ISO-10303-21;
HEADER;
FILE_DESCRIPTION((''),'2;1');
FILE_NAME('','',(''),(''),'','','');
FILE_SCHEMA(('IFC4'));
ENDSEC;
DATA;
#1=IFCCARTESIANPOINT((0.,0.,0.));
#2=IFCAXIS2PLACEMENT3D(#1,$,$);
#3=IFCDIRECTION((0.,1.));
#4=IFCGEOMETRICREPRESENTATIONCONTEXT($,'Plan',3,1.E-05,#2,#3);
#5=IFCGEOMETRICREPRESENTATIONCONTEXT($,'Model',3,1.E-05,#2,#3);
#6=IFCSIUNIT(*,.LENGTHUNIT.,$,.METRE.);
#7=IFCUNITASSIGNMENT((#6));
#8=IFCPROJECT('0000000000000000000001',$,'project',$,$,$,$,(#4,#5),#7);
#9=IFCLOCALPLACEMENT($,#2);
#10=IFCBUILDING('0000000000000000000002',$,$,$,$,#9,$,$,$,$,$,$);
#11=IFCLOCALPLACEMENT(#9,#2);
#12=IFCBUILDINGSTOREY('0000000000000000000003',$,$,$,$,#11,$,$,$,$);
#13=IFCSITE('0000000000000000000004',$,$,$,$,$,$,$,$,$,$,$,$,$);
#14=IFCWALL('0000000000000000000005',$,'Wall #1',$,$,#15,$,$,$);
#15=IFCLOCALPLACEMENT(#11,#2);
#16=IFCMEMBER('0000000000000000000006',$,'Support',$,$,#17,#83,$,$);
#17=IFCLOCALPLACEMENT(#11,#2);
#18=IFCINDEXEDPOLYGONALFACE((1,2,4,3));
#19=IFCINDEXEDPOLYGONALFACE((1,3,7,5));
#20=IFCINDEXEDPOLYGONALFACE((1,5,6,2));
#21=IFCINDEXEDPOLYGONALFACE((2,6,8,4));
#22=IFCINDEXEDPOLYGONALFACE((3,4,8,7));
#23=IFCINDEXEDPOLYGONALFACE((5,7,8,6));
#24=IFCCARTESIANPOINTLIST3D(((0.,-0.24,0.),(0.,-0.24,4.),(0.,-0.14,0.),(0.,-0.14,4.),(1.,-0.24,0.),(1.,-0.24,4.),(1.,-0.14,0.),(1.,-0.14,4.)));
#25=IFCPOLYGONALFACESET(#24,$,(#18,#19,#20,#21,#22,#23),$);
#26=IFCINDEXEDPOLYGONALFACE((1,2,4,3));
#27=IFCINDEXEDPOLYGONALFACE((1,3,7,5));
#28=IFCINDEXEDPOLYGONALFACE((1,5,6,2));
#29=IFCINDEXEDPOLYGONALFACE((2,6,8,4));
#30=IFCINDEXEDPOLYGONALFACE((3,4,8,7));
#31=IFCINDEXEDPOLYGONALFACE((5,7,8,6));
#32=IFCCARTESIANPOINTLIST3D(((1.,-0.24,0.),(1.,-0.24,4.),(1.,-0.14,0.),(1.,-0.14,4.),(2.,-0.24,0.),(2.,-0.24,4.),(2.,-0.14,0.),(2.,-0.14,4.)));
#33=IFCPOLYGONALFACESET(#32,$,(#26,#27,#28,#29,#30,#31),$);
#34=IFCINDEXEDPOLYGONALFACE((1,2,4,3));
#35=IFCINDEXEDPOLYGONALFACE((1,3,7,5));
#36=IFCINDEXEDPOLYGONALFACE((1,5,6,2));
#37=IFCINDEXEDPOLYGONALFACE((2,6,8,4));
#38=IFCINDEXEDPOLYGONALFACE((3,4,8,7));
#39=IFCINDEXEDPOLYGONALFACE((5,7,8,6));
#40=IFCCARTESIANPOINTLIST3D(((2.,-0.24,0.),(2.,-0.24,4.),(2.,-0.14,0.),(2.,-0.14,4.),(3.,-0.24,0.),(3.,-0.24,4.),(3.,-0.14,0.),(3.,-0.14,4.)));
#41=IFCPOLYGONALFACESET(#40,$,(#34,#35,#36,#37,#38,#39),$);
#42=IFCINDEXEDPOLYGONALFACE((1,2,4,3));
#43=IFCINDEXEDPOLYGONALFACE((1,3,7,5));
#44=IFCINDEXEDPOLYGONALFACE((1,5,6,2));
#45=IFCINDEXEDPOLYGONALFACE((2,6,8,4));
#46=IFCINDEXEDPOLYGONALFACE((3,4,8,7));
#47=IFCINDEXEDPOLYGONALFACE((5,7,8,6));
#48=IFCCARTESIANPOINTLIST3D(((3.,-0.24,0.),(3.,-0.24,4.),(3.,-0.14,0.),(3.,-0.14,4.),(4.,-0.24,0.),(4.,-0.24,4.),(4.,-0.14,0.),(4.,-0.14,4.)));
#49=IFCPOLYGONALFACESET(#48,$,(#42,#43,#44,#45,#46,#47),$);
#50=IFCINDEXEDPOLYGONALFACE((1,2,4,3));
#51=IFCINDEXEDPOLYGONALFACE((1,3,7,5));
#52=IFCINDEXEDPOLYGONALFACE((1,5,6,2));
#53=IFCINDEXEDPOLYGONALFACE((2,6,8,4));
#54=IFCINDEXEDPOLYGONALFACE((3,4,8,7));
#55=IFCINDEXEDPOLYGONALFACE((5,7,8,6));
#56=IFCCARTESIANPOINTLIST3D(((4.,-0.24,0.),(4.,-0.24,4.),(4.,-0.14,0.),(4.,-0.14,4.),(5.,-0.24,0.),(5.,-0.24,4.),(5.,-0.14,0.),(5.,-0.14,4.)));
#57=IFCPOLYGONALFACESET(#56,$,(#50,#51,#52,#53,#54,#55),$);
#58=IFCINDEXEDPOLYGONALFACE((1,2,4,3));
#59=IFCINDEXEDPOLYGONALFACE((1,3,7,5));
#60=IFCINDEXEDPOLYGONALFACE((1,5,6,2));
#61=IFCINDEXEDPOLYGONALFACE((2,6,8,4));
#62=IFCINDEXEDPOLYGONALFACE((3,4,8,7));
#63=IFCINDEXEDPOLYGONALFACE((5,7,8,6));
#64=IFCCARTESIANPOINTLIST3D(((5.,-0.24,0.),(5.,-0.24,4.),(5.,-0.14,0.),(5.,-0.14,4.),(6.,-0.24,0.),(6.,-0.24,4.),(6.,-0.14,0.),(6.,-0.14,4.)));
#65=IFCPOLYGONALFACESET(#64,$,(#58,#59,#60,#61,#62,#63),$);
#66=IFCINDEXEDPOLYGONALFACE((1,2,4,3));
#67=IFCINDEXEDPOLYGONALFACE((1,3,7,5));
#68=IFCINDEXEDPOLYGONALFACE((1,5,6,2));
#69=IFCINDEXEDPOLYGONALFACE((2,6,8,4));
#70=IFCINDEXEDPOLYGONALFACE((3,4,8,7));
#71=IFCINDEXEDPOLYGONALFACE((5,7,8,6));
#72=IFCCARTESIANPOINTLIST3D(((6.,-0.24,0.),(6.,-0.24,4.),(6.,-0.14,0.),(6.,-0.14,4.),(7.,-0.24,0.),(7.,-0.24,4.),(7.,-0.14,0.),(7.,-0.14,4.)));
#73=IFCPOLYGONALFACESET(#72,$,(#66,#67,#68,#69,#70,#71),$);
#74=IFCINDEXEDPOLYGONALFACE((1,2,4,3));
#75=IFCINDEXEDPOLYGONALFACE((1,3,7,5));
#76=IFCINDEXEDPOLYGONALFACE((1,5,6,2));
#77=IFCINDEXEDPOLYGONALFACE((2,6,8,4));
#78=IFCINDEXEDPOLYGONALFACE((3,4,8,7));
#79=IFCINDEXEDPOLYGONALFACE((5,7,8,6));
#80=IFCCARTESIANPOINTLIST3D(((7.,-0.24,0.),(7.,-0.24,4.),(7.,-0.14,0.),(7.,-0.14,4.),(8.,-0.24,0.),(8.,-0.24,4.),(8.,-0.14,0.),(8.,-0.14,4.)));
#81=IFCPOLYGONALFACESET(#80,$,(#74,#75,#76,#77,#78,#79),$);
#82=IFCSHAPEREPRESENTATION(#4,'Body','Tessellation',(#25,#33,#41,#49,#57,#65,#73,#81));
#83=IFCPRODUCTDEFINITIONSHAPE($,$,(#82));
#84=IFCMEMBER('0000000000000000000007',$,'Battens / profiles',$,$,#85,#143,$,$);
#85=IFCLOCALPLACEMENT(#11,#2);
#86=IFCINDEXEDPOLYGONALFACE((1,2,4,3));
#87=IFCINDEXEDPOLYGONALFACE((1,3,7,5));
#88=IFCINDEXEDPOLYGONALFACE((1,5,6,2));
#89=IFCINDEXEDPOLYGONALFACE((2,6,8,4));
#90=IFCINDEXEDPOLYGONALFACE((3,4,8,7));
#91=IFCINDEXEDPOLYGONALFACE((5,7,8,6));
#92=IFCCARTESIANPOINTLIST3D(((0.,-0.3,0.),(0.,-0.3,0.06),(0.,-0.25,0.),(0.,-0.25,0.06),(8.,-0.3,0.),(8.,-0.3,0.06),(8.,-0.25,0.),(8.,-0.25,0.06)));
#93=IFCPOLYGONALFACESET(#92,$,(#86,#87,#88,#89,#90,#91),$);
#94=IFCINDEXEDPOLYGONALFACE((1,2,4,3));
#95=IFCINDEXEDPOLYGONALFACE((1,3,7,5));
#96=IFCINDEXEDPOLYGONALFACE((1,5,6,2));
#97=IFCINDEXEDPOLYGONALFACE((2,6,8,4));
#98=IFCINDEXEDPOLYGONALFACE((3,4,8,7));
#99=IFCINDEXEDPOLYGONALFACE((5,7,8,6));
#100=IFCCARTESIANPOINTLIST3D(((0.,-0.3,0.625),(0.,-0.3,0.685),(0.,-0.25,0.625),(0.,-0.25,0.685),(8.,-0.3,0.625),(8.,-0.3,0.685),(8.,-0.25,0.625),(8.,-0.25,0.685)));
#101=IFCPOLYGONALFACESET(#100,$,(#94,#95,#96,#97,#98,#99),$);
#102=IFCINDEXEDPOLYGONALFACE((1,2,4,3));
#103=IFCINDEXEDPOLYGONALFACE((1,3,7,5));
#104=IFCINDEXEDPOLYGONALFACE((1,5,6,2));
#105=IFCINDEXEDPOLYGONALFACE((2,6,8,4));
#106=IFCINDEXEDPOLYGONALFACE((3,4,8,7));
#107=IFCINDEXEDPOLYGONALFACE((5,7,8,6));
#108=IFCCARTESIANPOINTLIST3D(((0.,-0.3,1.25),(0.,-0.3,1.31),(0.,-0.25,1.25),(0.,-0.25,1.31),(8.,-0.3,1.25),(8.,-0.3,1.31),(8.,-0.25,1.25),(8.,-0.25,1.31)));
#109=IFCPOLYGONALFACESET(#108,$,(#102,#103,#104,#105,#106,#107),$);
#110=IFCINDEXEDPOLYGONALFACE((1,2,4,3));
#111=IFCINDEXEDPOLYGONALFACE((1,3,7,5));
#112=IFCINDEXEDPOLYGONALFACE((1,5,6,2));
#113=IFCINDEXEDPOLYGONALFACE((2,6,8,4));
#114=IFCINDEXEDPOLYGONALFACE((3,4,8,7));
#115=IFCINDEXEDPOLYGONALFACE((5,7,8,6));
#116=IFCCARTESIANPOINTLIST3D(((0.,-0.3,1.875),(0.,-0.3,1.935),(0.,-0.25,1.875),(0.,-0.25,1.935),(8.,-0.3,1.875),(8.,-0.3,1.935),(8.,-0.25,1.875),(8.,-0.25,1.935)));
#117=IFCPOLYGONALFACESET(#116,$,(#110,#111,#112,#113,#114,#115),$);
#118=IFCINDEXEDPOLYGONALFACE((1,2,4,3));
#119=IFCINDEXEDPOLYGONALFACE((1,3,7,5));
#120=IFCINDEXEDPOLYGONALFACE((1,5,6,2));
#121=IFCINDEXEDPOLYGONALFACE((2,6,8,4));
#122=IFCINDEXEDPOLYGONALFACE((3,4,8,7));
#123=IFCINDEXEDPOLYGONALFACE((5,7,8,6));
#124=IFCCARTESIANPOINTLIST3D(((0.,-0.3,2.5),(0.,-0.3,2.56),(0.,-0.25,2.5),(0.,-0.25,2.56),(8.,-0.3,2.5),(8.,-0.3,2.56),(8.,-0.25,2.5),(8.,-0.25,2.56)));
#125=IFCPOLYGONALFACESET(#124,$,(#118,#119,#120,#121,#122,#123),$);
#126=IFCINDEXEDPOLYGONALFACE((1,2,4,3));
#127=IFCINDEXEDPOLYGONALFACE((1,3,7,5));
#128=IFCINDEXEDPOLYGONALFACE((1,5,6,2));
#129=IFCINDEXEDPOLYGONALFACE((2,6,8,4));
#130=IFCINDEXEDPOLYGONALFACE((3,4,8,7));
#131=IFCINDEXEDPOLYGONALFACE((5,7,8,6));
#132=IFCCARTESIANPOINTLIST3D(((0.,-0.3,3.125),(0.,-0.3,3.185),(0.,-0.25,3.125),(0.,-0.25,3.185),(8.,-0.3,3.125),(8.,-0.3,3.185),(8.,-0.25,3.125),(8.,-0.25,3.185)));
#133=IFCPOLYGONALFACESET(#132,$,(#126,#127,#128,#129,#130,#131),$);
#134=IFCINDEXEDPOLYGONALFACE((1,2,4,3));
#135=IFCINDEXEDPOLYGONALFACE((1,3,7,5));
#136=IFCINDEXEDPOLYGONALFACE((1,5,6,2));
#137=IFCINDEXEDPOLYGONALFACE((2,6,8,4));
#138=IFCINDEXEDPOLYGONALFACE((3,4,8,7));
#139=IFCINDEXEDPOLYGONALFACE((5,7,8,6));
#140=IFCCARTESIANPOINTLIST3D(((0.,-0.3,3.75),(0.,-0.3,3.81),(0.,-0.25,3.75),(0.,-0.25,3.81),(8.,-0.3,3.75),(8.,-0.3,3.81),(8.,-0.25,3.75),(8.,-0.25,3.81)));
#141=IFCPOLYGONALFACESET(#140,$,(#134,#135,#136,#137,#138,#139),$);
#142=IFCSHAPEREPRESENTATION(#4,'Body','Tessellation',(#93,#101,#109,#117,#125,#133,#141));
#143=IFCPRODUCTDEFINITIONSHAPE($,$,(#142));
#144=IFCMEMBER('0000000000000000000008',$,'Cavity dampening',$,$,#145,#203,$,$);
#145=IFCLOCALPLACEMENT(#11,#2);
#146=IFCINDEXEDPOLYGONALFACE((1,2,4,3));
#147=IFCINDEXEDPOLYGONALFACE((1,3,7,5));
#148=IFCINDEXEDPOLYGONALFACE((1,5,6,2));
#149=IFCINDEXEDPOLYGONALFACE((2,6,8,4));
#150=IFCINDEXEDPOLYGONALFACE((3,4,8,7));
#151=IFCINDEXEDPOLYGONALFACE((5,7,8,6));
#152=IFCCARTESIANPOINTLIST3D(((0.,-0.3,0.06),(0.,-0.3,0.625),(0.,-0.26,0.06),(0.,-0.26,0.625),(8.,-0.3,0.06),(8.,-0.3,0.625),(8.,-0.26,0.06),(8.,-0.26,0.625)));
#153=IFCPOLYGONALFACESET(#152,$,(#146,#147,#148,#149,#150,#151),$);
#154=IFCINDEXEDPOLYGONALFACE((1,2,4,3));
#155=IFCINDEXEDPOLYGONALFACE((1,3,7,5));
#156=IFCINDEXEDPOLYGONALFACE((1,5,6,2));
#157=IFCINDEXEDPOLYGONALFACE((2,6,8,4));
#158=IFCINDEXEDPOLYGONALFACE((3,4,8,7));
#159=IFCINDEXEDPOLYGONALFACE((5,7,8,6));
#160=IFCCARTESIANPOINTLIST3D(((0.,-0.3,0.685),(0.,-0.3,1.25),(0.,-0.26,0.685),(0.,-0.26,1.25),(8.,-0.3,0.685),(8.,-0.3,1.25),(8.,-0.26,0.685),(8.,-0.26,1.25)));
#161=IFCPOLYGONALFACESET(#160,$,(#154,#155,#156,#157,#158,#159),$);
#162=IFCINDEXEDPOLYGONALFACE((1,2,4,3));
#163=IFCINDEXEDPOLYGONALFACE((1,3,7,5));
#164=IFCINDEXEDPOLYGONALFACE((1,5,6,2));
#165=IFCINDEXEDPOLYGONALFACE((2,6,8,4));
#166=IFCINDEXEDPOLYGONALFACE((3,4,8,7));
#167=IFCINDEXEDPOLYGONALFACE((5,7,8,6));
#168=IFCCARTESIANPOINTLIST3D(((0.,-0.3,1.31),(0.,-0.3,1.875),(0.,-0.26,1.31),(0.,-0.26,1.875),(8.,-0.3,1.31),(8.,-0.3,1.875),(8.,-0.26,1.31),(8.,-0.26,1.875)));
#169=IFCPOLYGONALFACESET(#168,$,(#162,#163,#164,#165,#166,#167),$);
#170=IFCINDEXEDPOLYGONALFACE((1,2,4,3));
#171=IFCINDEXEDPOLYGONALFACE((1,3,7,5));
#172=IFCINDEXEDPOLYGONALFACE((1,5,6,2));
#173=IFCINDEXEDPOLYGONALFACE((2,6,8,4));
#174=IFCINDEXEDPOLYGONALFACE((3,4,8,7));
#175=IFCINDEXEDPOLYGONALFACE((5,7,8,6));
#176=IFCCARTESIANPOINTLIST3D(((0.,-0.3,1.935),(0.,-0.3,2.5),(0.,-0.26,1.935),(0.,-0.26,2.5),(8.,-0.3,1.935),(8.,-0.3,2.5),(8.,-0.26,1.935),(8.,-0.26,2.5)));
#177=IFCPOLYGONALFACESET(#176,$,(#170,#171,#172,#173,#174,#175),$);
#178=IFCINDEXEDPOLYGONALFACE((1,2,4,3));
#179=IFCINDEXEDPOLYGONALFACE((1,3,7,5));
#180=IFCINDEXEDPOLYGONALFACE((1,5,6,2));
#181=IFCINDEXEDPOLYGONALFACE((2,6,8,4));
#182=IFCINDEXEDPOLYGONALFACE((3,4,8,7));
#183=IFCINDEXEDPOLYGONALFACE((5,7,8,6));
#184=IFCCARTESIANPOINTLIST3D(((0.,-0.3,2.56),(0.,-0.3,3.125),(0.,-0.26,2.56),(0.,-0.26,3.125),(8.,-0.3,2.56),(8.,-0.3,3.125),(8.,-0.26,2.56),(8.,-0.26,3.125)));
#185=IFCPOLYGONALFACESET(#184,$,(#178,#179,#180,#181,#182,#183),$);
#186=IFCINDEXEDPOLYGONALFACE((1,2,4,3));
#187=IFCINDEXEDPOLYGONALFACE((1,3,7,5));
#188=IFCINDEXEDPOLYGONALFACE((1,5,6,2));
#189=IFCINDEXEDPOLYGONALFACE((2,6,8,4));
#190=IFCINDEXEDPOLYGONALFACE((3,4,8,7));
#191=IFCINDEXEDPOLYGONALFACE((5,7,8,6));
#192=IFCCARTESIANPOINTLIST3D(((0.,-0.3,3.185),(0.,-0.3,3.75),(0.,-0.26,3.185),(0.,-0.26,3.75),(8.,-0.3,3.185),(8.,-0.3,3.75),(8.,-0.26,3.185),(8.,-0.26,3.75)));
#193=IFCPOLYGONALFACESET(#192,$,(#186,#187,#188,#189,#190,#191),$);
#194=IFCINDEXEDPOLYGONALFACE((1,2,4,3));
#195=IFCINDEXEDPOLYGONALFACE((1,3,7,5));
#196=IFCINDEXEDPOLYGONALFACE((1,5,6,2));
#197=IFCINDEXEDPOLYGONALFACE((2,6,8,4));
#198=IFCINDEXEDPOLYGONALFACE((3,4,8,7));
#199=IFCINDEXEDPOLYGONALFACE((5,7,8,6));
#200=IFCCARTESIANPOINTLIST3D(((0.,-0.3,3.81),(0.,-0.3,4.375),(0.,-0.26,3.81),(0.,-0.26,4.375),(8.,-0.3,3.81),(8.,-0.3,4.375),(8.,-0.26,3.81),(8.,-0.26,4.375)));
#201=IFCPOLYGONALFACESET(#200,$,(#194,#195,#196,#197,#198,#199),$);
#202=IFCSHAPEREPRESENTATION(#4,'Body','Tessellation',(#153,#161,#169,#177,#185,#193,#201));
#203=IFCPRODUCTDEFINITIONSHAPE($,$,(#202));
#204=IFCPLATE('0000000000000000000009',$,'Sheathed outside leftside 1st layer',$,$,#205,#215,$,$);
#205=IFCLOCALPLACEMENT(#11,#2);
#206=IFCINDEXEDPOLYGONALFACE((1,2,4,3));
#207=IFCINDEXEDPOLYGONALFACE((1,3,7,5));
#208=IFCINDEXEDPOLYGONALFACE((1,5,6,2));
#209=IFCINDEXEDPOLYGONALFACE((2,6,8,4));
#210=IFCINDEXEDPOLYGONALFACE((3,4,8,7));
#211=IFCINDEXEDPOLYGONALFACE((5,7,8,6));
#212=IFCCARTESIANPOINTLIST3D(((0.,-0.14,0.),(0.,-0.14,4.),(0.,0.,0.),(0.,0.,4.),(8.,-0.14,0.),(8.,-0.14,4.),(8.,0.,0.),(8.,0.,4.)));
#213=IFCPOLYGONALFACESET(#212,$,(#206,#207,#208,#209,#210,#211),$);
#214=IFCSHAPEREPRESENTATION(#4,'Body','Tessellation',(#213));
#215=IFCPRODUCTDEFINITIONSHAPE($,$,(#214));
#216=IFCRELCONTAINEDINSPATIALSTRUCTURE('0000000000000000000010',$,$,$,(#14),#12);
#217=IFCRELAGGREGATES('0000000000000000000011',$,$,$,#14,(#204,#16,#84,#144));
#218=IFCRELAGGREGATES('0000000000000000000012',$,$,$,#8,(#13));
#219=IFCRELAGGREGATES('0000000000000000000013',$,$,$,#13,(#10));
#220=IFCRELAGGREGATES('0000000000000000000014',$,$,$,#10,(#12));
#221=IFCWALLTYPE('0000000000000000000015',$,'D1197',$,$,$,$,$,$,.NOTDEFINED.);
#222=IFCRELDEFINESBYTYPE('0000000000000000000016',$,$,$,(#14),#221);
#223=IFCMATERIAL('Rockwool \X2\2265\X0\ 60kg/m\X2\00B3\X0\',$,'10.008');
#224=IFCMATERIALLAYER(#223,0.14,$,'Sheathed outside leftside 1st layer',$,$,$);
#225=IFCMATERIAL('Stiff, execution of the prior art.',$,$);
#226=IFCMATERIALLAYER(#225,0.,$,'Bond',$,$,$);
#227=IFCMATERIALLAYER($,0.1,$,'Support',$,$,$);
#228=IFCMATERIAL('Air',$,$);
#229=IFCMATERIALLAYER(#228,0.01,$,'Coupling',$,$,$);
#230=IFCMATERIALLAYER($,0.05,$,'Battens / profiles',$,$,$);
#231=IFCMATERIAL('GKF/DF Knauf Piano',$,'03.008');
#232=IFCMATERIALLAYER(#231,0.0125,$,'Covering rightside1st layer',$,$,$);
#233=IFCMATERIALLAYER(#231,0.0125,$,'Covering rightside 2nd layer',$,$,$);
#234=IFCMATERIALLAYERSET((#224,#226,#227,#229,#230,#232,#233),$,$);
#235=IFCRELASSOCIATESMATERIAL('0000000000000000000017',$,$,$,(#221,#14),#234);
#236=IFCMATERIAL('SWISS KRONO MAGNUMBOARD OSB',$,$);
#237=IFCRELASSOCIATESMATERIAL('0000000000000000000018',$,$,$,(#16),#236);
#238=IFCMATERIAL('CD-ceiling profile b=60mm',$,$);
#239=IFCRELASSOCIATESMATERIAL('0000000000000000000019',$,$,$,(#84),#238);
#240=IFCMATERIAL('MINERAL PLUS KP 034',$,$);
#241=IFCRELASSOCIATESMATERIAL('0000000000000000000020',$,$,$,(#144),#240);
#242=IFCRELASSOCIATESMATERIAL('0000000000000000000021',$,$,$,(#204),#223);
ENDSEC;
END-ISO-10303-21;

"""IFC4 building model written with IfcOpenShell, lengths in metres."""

from ifc_helpers import new_model, si_unit, direction, frame, frame_2d, origin, origin_with_axes, place, context, project, spatial, rectangle, extrude, material, layer, layer_set, type_object, element, aggregate, save


model = new_model("IFC4")

# Units and contexts
plan_context = context("Plan", 3, precision=1e-05, world=origin(), true_north=direction((0.0, 1.0)))
model_context = context("Model", 3, precision=1e-05, world=origin(), true_north=direction((0.0, 1.0)))
ifc_project = project(units=[si_unit("LENGTHUNIT", "METRE")], contexts=[plan_context, model_context])

# Site, building, storey
site = spatial("IfcSite", under=ifc_project)
building_placement = place(None, origin())
building = spatial("IfcBuilding", under=site, at=building_placement)
storey_placement = place(building_placement, origin())
storey = spatial("IfcBuildingStorey", under=building, at=storey_placement)

# Wall, members, plate
ifc_material_1 = material(Name="Rockwool ≥ 60kg/m³", Category="10.008")
ifc_layer_1 = layer(ifc_material_1, 0.14, Name="Sheathed outside leftside 1st layer")
ifc_material_2 = material(Name="Stiff, execution of the prior art.")
ifc_layer_2 = layer(ifc_material_2, 0.0, Name="Bond")
ifc_layer_3 = layer(None, 0.1, Name="Support")
ifc_material_3 = material(Name="Air")
ifc_layer_4 = layer(ifc_material_3, 0.01, Name="Coupling")
ifc_layer_5 = layer(None, 0.05, Name="Battens / profiles")
ifc_material_4 = material(Name="GKF/DF Knauf Piano", Category="03.008")
ifc_layer_6 = layer(ifc_material_4, 0.0125, Name="Covering rightside1st layer")
ifc_layer_7 = layer(ifc_material_4, 0.0125, Name="Covering rightside 2nd layer")
ifc_layer_set = layer_set([ifc_layer_1, ifc_layer_2, ifc_layer_3, ifc_layer_4, ifc_layer_5, ifc_layer_6, ifc_layer_7])
wall_type = type_object("IfcWallType", Name="D1197", PredefinedType="NOTDEFINED", material=ifc_layer_set)
wall_placement = place(None, frame((0.0, 0.0, 0.0), z_axis=(0.0, -1.0, 0.0), x_axis=(1.0, 0.0, 0.0)))
wall = element("IfcWall", 1, at=wall_placement, inside=storey, type_object=wall_type, material=ifc_layer_set, Name="Wall #1")
ifc_material_5 = material(Name="SWISS KRONO MAGNUMBOARD OSB")
member_1_placement = place(wall_placement, origin())
member_1 = element("IfcMember", 2, at=member_1_placement, material=ifc_material_5, Name="Support", context=plan_context, shape_type="SweptSolid", body=[
    extrude(rectangle(XDim=1.0, YDim=0.1, at=frame_2d((0.5, 0.05), x_axis=(1.0, 0.0))), frame((0.0, 4.0, 0.14), z_axis=(0.0, -1.0, 0.0), x_axis=(1.0, 0.0, 0.0)), (0.0, 0.0, 1.0), 4.0),
    extrude(rectangle(XDim=1.0, YDim=0.1, at=frame_2d((0.5, 0.05), x_axis=(1.0, 0.0))), frame((1.0, 4.0, 0.14), z_axis=(0.0, -1.0, 0.0), x_axis=(1.0, 0.0, 0.0)), (0.0, 0.0, 1.0), 4.0),
    extrude(rectangle(XDim=1.0, YDim=0.1, at=frame_2d((0.5, 0.05), x_axis=(1.0, 0.0))), frame((2.0, 4.0, 0.14), z_axis=(0.0, -1.0, 0.0), x_axis=(1.0, 0.0, 0.0)), (0.0, 0.0, 1.0), 4.0),
    extrude(rectangle(XDim=1.0, YDim=0.1, at=frame_2d((0.5, 0.05), x_axis=(1.0, 0.0))), frame((3.0, 4.0, 0.14), z_axis=(0.0, -1.0, 0.0), x_axis=(1.0, 0.0, 0.0)), (0.0, 0.0, 1.0), 4.0),
    extrude(rectangle(XDim=1.0, YDim=0.1, at=frame_2d((0.5, 0.05), x_axis=(1.0, 0.0))), frame((4.0, 4.0, 0.14), z_axis=(0.0, -1.0, 0.0), x_axis=(1.0, 0.0, 0.0)), (0.0, 0.0, 1.0), 4.0),
    extrude(rectangle(XDim=1.0, YDim=0.1, at=frame_2d((0.5, 0.05), x_axis=(1.0, 0.0))), frame((5.0, 4.0, 0.14), z_axis=(0.0, -1.0, 0.0), x_axis=(1.0, 0.0, 0.0)), (0.0, 0.0, 1.0), 4.0),
    extrude(rectangle(XDim=1.0, YDim=0.1, at=frame_2d((0.5, 0.05), x_axis=(1.0, 0.0))), frame((6.0, 4.0, 0.14), z_axis=(0.0, -1.0, 0.0), x_axis=(1.0, 0.0, 0.0)), (0.0, 0.0, 1.0), 4.0),
    extrude(rectangle(XDim=1.0, YDim=0.1, at=frame_2d((0.5, 0.05), x_axis=(1.0, 0.0))), frame((7.0, 4.0, 0.14), z_axis=(0.0, -1.0, 0.0), x_axis=(1.0, 0.0, 0.0)), (0.0, 0.0, 1.0), 4.0),
])
ifc_material_6 = material(Name="CD-ceiling profile b=60mm")
member_2_placement = place(wall_placement, origin())
member_2 = element("IfcMember", 3, at=member_2_placement, material=ifc_material_6, Name="Battens / profiles", context=plan_context, shape_type="SweptSolid", body=[
    extrude(rectangle(XDim=0.06, YDim=0.05, at=frame_2d((0.03, 0.025), x_axis=(1.0, 0.0))), frame((0.0, 0.0, 0.25), z_axis=(1.0, 0.0, 0.0), x_axis=(0.0, 1.0, 0.0)), (0.0, 0.0, 1.0), 8.0),
    extrude(rectangle(XDim=0.06, YDim=0.05, at=frame_2d((0.03, 0.025), x_axis=(1.0, 0.0))), frame((0.0, 0.625, 0.25), z_axis=(1.0, 0.0, 0.0), x_axis=(0.0, 1.0, 0.0)), (0.0, 0.0, 1.0), 8.0),
    extrude(rectangle(XDim=0.06, YDim=0.05, at=frame_2d((0.03, 0.025), x_axis=(1.0, 0.0))), frame((0.0, 1.25, 0.25), z_axis=(1.0, 0.0, 0.0), x_axis=(0.0, 1.0, 0.0)), (0.0, 0.0, 1.0), 8.0),
    extrude(rectangle(XDim=0.06, YDim=0.05, at=frame_2d((0.03, 0.025), x_axis=(1.0, 0.0))), frame((0.0, 1.875, 0.25), z_axis=(1.0, 0.0, 0.0), x_axis=(0.0, 1.0, 0.0)), (0.0, 0.0, 1.0), 8.0),
    extrude(rectangle(XDim=0.06, YDim=0.05, at=frame_2d((0.03, 0.025), x_axis=(1.0, 0.0))), frame((0.0, 2.5, 0.25), z_axis=(1.0, 0.0, 0.0), x_axis=(0.0, 1.0, 0.0)), (0.0, 0.0, 1.0), 8.0),
    extrude(rectangle(XDim=0.06, YDim=0.05, at=frame_2d((0.03, 0.025), x_axis=(1.0, 0.0))), frame((0.0, 3.125, 0.25), z_axis=(1.0, 0.0, 0.0), x_axis=(0.0, 1.0, 0.0)), (0.0, 0.0, 1.0), 8.0),
    extrude(rectangle(XDim=0.06, YDim=0.05, at=frame_2d((0.03, 0.025), x_axis=(1.0, 0.0))), frame((0.0, 3.75, 0.25), z_axis=(1.0, 0.0, 0.0), x_axis=(0.0, 1.0, 0.0)), (0.0, 0.0, 1.0), 8.0),
])
ifc_material_7 = material(Name="MINERAL PLUS KP 034")
member_3_placement = place(wall_placement, origin())
member_3 = element("IfcMember", 4, at=member_3_placement, material=ifc_material_7, Name="Cavity dampening", context=plan_context, shape_type="SweptSolid", body=[
    extrude(rectangle(XDim=0.565, YDim=0.04, at=frame_2d((0.2825, 0.02), x_axis=(1.0, 0.0))), frame((0.0, 0.06, 0.26), z_axis=(1.0, 0.0, 0.0), x_axis=(0.0, 1.0, 0.0)), (0.0, 0.0, 1.0), 8.0),
    extrude(rectangle(XDim=0.565, YDim=0.04, at=frame_2d((0.2825, 0.02), x_axis=(1.0, 0.0))), frame((0.0, 0.685, 0.26), z_axis=(1.0, 0.0, 0.0), x_axis=(0.0, 1.0, 0.0)), (0.0, 0.0, 1.0), 8.0),
    extrude(rectangle(XDim=0.565, YDim=0.04, at=frame_2d((0.2825, 0.02), x_axis=(1.0, 0.0))), frame((0.0, 1.31, 0.26), z_axis=(1.0, 0.0, 0.0), x_axis=(0.0, 1.0, 0.0)), (0.0, 0.0, 1.0), 8.0),
    extrude(rectangle(XDim=0.565, YDim=0.04, at=frame_2d((0.2825, 0.02), x_axis=(1.0, 0.0))), frame((0.0, 1.935, 0.26), z_axis=(1.0, 0.0, 0.0), x_axis=(0.0, 1.0, 0.0)), (0.0, 0.0, 1.0), 8.0),
    extrude(rectangle(XDim=0.565, YDim=0.04, at=frame_2d((0.2825, 0.02), x_axis=(1.0, 0.0))), frame((0.0, 2.56, 0.26), z_axis=(1.0, 0.0, 0.0), x_axis=(0.0, 1.0, 0.0)), (0.0, 0.0, 1.0), 8.0),
    extrude(rectangle(XDim=0.565, YDim=0.04, at=frame_2d((0.2825, 0.02), x_axis=(1.0, 0.0))), frame((0.0, 3.185, 0.26), z_axis=(1.0, 0.0, 0.0), x_axis=(0.0, 1.0, 0.0)), (0.0, 0.0, 1.0), 8.0),
    extrude(rectangle(XDim=0.565, YDim=0.04, at=frame_2d((0.2825, 0.02), x_axis=(1.0, 0.0))), frame((0.0, 3.81, 0.26), z_axis=(1.0, 0.0, 0.0), x_axis=(0.0, 1.0, 0.0)), (0.0, 0.0, 1.0), 8.0),
])
plate_1_placement = place(wall_placement, origin())
plate_1 = element("IfcPlate", 5, at=plate_1_placement, material=ifc_material_1, Name="Sheathed outside leftside 1st layer", context=plan_context, shape_type="SweptSolid", body=[
    extrude(rectangle(XDim=8.0, YDim=4.0, at=frame_2d((4.0, 2.0), x_axis=(1.0, 0.0))), origin_with_axes(), (0.0, 0.0, 1.0), 0.14),
])
aggregate(wall, [plate_1, member_1, member_2, member_3])

save(model, "model.ifc")
